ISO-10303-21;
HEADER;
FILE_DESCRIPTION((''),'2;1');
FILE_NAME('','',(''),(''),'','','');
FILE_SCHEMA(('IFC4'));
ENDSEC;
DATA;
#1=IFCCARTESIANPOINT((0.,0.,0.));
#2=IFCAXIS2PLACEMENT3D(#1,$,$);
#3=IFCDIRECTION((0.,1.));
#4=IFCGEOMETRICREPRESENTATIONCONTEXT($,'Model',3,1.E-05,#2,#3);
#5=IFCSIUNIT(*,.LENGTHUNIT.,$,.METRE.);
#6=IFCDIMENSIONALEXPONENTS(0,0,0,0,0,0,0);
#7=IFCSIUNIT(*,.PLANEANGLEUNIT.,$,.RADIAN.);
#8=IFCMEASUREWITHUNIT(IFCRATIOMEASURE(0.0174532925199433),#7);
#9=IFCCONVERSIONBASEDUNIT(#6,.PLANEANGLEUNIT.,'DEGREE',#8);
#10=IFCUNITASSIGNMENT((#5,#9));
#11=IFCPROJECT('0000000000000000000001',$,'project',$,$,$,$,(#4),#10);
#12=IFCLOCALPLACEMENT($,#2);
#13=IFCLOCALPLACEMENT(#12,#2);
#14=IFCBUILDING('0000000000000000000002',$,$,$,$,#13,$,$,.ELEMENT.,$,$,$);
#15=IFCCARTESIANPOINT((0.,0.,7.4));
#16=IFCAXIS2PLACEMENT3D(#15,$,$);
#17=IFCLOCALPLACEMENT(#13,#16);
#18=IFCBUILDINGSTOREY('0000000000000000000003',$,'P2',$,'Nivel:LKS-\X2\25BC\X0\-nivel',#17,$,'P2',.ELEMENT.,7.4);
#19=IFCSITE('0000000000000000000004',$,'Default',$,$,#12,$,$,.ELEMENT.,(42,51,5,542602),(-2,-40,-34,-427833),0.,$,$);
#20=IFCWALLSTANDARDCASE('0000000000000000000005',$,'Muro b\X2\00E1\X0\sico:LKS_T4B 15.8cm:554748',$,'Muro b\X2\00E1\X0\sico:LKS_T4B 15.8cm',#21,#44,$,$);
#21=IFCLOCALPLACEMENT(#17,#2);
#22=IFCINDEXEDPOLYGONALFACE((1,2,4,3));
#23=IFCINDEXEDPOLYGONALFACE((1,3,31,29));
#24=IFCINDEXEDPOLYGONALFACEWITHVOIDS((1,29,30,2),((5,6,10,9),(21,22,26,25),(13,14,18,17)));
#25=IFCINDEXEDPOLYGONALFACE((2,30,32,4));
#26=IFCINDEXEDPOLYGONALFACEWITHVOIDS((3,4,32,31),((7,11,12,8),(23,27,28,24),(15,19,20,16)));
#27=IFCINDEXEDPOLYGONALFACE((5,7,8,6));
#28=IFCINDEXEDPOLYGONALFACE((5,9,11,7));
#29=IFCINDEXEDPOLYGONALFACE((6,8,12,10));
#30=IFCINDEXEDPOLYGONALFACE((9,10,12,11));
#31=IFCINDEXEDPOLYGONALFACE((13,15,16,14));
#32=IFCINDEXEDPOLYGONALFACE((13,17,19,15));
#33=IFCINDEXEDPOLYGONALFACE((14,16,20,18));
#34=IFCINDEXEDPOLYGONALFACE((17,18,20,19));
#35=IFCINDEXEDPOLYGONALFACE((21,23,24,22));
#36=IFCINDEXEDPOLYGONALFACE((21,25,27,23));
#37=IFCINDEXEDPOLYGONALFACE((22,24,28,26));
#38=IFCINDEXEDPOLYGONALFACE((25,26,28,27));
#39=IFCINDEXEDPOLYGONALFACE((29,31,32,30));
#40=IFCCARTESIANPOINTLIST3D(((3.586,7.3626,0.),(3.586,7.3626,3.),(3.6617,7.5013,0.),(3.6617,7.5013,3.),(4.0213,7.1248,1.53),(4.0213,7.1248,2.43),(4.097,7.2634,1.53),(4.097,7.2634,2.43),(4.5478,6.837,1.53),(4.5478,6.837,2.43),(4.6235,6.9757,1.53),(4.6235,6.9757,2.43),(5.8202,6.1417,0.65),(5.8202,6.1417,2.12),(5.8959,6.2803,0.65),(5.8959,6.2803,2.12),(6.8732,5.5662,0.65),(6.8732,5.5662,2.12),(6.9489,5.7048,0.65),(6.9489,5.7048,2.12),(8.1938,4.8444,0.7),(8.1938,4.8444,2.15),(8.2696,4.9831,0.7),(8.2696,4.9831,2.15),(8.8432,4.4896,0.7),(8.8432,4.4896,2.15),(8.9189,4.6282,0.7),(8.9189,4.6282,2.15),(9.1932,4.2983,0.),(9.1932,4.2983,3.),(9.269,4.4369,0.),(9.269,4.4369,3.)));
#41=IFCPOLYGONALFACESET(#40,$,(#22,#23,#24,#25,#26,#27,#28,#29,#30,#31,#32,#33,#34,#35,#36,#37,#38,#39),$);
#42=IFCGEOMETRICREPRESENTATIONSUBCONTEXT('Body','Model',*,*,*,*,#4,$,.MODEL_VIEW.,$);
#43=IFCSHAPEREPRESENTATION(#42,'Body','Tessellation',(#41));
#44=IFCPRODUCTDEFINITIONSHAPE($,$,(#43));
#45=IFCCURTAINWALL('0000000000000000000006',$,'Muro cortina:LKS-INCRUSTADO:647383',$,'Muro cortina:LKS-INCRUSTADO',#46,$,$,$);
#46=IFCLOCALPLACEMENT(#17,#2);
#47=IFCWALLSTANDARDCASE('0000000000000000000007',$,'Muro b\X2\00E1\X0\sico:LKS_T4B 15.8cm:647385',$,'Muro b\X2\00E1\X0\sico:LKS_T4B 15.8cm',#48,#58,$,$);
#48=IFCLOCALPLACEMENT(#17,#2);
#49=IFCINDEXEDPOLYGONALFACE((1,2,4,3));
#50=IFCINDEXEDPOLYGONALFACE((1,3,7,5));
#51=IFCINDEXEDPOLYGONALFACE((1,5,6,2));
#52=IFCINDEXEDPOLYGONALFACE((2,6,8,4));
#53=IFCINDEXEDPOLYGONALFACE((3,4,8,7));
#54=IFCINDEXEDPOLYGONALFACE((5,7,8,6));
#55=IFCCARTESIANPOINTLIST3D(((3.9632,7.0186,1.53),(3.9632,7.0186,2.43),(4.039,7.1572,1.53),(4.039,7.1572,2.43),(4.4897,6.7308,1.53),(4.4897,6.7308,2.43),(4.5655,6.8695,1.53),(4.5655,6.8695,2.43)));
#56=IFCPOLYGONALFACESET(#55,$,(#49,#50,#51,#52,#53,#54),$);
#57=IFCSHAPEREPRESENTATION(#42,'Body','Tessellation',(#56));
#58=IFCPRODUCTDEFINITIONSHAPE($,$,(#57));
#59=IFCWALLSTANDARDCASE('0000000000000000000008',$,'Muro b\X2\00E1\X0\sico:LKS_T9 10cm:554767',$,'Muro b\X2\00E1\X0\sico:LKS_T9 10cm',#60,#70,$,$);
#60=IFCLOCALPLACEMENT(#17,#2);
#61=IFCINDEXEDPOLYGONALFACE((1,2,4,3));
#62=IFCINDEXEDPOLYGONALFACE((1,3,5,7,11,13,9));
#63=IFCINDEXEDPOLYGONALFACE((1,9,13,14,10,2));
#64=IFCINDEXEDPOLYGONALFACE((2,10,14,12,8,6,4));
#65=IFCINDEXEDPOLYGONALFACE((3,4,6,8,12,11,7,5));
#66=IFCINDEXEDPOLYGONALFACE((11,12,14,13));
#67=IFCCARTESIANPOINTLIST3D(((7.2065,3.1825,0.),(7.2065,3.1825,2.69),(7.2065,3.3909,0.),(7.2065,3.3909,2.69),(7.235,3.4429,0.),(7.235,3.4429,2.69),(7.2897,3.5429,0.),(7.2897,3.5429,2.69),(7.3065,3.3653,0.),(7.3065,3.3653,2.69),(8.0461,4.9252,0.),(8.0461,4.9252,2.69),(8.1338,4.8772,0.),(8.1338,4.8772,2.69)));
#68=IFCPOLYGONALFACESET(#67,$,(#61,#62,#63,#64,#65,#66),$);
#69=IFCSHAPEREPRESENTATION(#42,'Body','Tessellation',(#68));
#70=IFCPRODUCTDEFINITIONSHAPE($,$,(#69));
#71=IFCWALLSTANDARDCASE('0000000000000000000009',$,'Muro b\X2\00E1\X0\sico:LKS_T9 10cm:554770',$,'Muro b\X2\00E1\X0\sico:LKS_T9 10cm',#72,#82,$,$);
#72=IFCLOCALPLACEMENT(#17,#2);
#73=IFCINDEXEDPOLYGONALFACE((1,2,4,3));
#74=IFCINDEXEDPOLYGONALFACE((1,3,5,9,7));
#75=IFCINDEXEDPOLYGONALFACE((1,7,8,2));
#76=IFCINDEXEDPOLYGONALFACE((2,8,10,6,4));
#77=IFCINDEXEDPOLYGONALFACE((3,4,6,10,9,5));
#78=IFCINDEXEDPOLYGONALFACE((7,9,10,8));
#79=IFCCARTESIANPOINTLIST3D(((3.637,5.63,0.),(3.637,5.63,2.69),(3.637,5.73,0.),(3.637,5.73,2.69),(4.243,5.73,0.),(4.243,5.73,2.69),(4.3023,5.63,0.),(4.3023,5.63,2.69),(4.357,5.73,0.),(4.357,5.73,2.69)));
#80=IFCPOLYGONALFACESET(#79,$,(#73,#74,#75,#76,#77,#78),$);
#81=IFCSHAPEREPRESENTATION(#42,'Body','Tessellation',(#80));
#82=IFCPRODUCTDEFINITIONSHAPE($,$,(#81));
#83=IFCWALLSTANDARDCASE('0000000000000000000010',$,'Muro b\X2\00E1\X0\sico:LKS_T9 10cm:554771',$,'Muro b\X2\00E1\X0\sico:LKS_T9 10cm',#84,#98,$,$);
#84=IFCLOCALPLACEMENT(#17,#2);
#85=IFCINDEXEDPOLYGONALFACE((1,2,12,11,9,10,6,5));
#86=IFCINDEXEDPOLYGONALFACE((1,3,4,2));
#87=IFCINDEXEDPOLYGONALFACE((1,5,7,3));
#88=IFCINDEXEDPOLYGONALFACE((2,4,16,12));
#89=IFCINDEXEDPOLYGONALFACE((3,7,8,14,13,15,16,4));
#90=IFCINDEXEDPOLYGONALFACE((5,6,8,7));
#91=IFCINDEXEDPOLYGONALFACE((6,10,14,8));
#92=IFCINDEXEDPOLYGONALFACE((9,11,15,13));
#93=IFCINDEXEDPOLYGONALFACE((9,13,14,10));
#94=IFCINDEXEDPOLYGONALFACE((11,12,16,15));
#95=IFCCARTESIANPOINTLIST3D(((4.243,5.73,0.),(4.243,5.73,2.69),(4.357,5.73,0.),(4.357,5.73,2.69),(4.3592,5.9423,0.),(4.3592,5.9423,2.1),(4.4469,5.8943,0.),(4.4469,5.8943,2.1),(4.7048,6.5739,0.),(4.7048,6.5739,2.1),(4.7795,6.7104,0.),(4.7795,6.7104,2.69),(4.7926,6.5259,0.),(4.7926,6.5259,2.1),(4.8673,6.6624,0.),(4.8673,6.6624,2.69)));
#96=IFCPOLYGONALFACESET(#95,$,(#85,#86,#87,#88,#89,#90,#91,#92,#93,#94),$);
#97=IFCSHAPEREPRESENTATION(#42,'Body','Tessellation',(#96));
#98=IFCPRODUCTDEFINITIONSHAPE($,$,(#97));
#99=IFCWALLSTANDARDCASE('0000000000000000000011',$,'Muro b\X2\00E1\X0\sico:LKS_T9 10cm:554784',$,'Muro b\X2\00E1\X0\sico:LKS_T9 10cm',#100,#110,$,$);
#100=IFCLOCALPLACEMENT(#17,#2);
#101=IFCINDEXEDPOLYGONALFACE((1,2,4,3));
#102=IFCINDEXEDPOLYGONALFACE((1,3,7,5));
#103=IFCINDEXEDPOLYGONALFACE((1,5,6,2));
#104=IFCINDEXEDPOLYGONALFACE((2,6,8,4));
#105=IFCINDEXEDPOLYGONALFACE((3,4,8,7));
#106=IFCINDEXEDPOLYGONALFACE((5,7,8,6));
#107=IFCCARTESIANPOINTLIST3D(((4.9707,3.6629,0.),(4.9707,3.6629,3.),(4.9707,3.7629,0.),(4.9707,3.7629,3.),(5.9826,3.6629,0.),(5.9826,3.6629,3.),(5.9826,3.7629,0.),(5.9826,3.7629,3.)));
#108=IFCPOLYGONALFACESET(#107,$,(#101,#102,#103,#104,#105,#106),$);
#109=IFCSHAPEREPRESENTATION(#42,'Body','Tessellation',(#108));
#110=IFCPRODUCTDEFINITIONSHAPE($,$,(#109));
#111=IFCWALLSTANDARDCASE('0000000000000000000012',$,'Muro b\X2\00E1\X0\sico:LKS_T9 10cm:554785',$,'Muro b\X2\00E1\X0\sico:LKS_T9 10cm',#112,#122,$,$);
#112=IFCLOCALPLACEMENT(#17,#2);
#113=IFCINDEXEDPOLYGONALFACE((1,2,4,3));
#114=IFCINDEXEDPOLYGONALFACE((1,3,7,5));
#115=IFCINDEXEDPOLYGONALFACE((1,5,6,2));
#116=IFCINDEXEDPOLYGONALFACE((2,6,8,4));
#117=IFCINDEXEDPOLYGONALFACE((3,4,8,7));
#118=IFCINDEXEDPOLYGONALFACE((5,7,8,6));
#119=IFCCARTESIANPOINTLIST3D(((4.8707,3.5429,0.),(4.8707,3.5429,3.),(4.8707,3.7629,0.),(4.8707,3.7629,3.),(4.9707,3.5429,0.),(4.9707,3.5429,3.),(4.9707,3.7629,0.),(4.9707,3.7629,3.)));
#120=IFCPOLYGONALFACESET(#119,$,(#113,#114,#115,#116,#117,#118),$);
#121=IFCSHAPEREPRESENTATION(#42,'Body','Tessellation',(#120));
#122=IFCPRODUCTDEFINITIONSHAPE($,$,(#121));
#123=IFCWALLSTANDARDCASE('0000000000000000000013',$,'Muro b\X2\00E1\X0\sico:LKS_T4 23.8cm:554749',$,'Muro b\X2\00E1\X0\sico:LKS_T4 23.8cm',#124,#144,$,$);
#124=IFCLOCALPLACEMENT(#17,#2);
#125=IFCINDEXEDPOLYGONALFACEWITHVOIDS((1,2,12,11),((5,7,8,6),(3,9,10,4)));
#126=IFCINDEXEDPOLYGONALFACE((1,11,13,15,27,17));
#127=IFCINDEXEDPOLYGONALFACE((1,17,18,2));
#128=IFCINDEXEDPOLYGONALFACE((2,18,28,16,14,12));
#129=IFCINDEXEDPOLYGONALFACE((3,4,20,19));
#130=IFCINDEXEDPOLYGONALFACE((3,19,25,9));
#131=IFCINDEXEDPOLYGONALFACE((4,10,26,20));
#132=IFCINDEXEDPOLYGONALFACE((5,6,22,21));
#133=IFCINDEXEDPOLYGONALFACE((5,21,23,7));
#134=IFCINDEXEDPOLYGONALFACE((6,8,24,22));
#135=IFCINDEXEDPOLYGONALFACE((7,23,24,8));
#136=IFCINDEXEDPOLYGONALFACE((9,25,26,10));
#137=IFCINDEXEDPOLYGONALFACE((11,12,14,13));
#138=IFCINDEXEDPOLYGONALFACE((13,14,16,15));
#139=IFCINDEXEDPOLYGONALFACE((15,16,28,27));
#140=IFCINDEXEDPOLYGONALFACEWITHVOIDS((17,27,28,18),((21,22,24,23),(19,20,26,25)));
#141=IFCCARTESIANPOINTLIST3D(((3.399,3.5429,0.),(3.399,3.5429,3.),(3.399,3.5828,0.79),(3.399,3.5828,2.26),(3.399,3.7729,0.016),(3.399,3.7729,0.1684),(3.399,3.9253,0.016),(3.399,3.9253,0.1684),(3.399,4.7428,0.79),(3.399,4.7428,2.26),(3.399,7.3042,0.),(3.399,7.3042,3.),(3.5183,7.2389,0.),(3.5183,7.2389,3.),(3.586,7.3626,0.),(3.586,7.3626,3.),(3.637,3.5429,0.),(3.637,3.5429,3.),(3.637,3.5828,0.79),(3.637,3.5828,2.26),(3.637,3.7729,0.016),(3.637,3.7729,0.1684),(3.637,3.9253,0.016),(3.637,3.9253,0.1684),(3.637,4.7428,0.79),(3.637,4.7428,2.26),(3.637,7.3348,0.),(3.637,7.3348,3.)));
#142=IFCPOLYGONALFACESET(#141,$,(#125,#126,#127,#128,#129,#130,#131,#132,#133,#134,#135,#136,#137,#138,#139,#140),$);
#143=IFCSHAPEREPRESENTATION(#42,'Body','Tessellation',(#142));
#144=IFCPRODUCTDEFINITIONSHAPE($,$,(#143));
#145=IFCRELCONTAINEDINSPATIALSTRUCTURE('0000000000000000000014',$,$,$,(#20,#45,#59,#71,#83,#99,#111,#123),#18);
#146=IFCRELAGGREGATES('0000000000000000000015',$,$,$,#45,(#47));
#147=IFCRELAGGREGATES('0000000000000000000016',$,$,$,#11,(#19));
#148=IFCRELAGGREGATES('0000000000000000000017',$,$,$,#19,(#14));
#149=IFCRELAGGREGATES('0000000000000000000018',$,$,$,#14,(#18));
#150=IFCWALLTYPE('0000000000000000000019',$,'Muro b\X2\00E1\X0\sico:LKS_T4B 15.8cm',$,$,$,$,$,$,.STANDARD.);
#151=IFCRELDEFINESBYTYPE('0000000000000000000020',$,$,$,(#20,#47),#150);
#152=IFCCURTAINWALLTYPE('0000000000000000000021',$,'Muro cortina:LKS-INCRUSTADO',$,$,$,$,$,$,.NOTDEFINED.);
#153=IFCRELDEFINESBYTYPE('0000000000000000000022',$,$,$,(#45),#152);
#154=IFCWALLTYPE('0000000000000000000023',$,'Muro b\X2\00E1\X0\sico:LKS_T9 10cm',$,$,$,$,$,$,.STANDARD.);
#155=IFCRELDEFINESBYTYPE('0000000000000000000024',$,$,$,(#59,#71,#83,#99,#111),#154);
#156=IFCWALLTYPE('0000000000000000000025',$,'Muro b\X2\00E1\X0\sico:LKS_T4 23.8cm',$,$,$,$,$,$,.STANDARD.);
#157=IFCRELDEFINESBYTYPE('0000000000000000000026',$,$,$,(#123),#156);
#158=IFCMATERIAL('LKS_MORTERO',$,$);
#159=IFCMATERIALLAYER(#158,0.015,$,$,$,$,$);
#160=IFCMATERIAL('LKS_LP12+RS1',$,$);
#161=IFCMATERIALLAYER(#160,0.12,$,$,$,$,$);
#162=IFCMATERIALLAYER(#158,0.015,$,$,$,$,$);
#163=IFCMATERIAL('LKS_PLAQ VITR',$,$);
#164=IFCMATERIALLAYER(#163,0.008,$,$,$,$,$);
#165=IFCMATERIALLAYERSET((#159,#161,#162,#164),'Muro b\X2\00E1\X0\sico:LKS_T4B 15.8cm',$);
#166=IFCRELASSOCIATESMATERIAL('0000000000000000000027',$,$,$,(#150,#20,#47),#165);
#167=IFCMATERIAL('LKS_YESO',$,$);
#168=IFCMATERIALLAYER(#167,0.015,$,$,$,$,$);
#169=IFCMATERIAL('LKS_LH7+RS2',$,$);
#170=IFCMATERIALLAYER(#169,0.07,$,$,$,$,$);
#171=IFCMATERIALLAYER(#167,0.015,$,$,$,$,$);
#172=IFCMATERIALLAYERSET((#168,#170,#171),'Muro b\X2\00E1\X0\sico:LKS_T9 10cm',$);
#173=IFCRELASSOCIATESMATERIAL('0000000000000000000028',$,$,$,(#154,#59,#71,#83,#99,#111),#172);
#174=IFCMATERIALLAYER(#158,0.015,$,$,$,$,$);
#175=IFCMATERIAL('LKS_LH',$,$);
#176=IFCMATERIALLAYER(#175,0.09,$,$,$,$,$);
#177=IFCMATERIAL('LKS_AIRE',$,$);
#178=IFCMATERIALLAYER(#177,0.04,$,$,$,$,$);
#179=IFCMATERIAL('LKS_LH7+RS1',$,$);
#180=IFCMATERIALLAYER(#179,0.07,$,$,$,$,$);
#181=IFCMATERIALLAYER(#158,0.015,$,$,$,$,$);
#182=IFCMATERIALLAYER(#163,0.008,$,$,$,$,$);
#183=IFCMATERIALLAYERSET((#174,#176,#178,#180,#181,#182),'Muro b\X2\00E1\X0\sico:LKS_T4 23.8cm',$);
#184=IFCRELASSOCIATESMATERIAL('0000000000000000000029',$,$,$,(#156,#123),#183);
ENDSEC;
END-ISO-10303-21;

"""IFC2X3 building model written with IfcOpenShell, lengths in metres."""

from ifc_helpers import new_model, entity, si_unit, converted_unit, direction, frame, frame_2d, origin, place, context, subcontext, project, spatial, polyline, rectangle, outline, extrude, clip, bounded_halfspace, material, layer, layer_set, layer_usage, type_object, element, aggregate, save


model = new_model("IFC2X3")

# Units and contexts
model_context = context("Model", 3, precision=1e-05, world=origin(), true_north=direction((0.0, 1.0)))
body_context = subcontext(model_context, "Body", "Model", "MODEL_VIEW")
ifc_project = project(units=[si_unit("LENGTHUNIT", "METRE"), converted_unit("PLANEANGLEUNIT", "DEGREE", entity("IfcRatioMeasure", 0.0174532925199433), si_unit("PLANEANGLEUNIT", "RADIAN"), dimensions=[0, 0, 0, 0, 0, 0, 0])], contexts=[model_context])

# Site, building, storey
site_placement = place(None, origin())
site = spatial("IfcSite", under=ifc_project, at=site_placement, Name="Default", CompositionType="ELEMENT", RefLatitude=(42, 51, 5, 542602), RefLongitude=(-2, -40, -34, -427833), RefElevation=0.0)
building_placement = place(site_placement, origin())
building = spatial("IfcBuilding", under=site, at=building_placement, CompositionType="ELEMENT")
storey_placement = place(building_placement, frame((0.0, 0.0, 7.4)))
storey = spatial("IfcBuildingStorey", under=building, at=storey_placement, Name="P2", ObjectType="Nivel:LKS-▼-nivel", LongName="P2", CompositionType="ELEMENT", Elevation=7.4)

# Wall, openings
ifc_material_1 = material(Name="LKS_MORTERO")
ifc_layer_1 = layer(ifc_material_1, 0.015)
ifc_material_2 = material(Name="LKS_LP12+RS1")
ifc_layer_2 = layer(ifc_material_2, 0.12)
ifc_layer_3 = layer(ifc_material_1, 0.015)
ifc_material_3 = material(Name="LKS_PLAQ VITR")
ifc_layer_4 = layer(ifc_material_3, 0.008)
ifc_layer_set_1 = layer_set([ifc_layer_1, ifc_layer_2, ifc_layer_3, ifc_layer_4], Name="Muro básico:LKS_T4B 15.8cm")
ifc_layer_usage_1 = layer_usage(ifc_layer_set_1, "AXIS2", "POSITIVE", -0.079)
wall_type_1 = type_object("IfcWallType", Name="Muro básico:LKS_T4B 15.8cm", PredefinedType="STANDARD", material=ifc_layer_set_1)
wall_1_placement = place(storey_placement, frame((9.2311, 4.3676, 0.0), z_axis=(0.0, 0.0, 1.0), x_axis=(-0.877509, 0.479561, 0.0)))
wall_1 = element("IfcWallStandardCase", 1, at=wall_1_placement, inside=storey, type_object=wall_type_1, material=ifc_layer_usage_1, Name="Muro básico:LKS_T4B 15.8cm:554748", ObjectType="Muro básico:LKS_T4B 15.8cm", context=body_context, shape_type="Clipping", body=[
    clip(clip(extrude(rectangle(XDim=6.39, YDim=0.158, at=frame_2d((3.195, 0.0), x_axis=(-1.0, 0.0))), origin(), (0.0, 0.0, 1.0), 3.0), bounded_halfspace(frame((0.0, -0.079, 0.0), z_axis=(1.0, 0.0, 0.0), x_axis=(0.0, 0.0, -1.0)), True, frame((0.0, -0.079, 0.0), z_axis=(1.0, 0.0, 0.0), x_axis=(0.0, 0.0, -1.0)), polyline([(0.0, 0.0), (0.0, 0.158), (-3.0, 0.158), (-3.0, 0.0488), (-3.0, 0.0), (0.0, 0.0)]))), bounded_halfspace(frame((6.39, -0.079, 3.0), z_axis=(-1.0, 0.0, 0.0), x_axis=(0.0, 0.0, -1.0)), True, frame((6.39, -0.079, 3.0), z_axis=(-1.0, 0.0, 0.0), x_axis=(0.0, 0.0, -1.0)), polyline([(0.0, 0.0), (0.0, -0.0455), (0.0, -0.158), (3.0, -0.158), (3.0, 0.0), (0.0, 0.0)]))),
])
opening_1_placement = place(wall_1_placement, origin())
element("IfcOpeningElement", 2, at=opening_1_placement, cuts=wall_1, ObjectType="Opening", context=body_context, shape_type="SweptSolid", body=[
    extrude(rectangle(XDim=0.9, YDim=0.6, at=frame_2d((0.0, 0.0), x_axis=(0.0, 1.0))), frame((5.5939, -0.2314, 1.98), z_axis=(0.0, 1.0, 0.0), x_axis=(-1.0, 0.0, 0.0)), (0.0, 0.0, 1.0), 0.4628),
])
opening_2_placement = place(wall_1_placement, frame((3.8439, 0.079, 0.65)))
element("IfcOpeningElement", 3, at=opening_2_placement, cuts=wall_1, ObjectType="Opening", context=body_context, shape_type="SweptSolid", body=[
    extrude(rectangle(XDim=1.47, YDim=1.2, at=frame_2d((0.735, 0.6), x_axis=(1.0, 0.0))), frame((0.0, 0.0, 0.0), z_axis=(0.0, -1.0, 0.0), x_axis=(0.0, 0.0, 1.0)), (0.0, 0.0, 1.0), 0.158),
])
opening_3_placement = place(wall_1_placement, frame((1.1389, 0.079, 0.7)))
element("IfcOpeningElement", 4, at=opening_3_placement, cuts=wall_1, ObjectType="Opening", context=body_context, shape_type="SweptSolid", body=[
    extrude(rectangle(XDim=1.45, YDim=0.74, at=frame_2d((0.725, 0.37), x_axis=(1.0, 0.0))), frame((0.0, 0.0, 0.0), z_axis=(0.0, -1.0, 0.0), x_axis=(0.0, 0.0, 1.0)), (0.0, 0.0, 1.0), 0.158),
])

# Curtain wall, wall
curtain_wall_type = type_object("IfcCurtainWallType", Name="Muro cortina:LKS-INCRUSTADO", PredefinedType="NOTDEFINED")
curtain_wall_placement = place(storey_placement, frame((0.0, 0.0, -7.4)))
curtain_wall = element("IfcCurtainWall", 5, at=curtain_wall_placement, inside=storey, type_object=curtain_wall_type, Name="Muro cortina:LKS-INCRUSTADO:647383", ObjectType="Muro cortina:LKS-INCRUSTADO")
ifc_layer_usage_2 = layer_usage(ifc_layer_set_1, "AXIS2", "NEGATIVE", 0.079)
wall_2_placement = place(storey_placement, frame((4.0011, 7.0879, 1.53), z_axis=(0.0, 0.0, 1.0), x_axis=(0.877509, -0.479561, 0.0)))
wall_2 = element("IfcWallStandardCase", 6, at=wall_2_placement, type_object=wall_type_1, material=ifc_layer_usage_2, Name="Muro básico:LKS_T4B 15.8cm:647385", ObjectType="Muro básico:LKS_T4B 15.8cm", context=body_context, shape_type="SweptSolid", body=[
    extrude(rectangle(XDim=0.6, YDim=0.158, at=frame_2d((0.3, 0.0), x_axis=(-1.0, 0.0))), origin(), (0.0, 0.0, 1.0), 0.9),
])
aggregate(curtain_wall, [wall_2])

# Walls
ifc_material_4 = material(Name="LKS_YESO")
ifc_layer_5 = layer(ifc_material_4, 0.015)
ifc_material_5 = material(Name="LKS_LH7+RS2")
ifc_layer_6 = layer(ifc_material_5, 0.07)
ifc_layer_7 = layer(ifc_material_4, 0.015)
ifc_layer_set_2 = layer_set([ifc_layer_5, ifc_layer_6, ifc_layer_7], Name="Muro básico:LKS_T9 10cm")
ifc_layer_usage_3 = layer_usage(ifc_layer_set_2, "AXIS2", "NEGATIVE", 0.05)
wall_type_2 = type_object("IfcWallType", Name="Muro básico:LKS_T9 10cm", PredefinedType="STANDARD", material=ifc_layer_set_2)
wall_3_placement = place(storey_placement, frame((8.09, 4.9012, 0.0), z_axis=(0.0, 0.0, 1.0), x_axis=(-0.480022, -0.877256, 0.0)))
element("IfcWallStandardCase", 7, at=wall_3_placement, inside=storey, type_object=wall_type_2, material=ifc_layer_usage_3, Name="Muro básico:LKS_T9 10cm:554767", ObjectType="Muro básico:LKS_T9 10cm", context=body_context, shape_type="SweptSolid", body=[
    extrude(outline(polyline([(1.749, -0.05), (1.9318, 0.05), (1.7235, 0.05), (0.0, 0.05), (0.0001, -0.05), (1.5758, -0.05), (1.6897, -0.05), (1.749, -0.05)])), origin(), (0.0, 0.0, 1.0), 2.69),
])
ifc_layer_usage_4 = layer_usage(ifc_layer_set_2, "AXIS2", "NEGATIVE", 0.05)
wall_4_placement = place(storey_placement, frame((3.637, 5.68, 0.0)))
element("IfcWallStandardCase", 8, at=wall_4_placement, inside=storey, type_object=wall_type_2, material=ifc_layer_usage_4, Name="Muro básico:LKS_T9 10cm:554770", ObjectType="Muro básico:LKS_T9 10cm", context=body_context, shape_type="SweptSolid", body=[
    extrude(outline(polyline([(0.6654, -0.05), (0.7201, 0.05), (0.6061, 0.05), (0.0, 0.05), (0.0, -0.05), (0.6654, -0.05)])), origin(), (0.0, 0.0, 1.0), 2.69),
])

# Wall, opening
ifc_layer_usage_5 = layer_usage(ifc_layer_set_2, "AXIS2", "NEGATIVE", 0.05)
wall_5_placement = place(storey_placement, frame((4.2869, 5.706, 0.0), z_axis=(0.0, 0.0, 1.0), x_axis=(0.480022, 0.877256, 0.0)))
wall_5 = element("IfcWallStandardCase", 9, at=wall_5_placement, inside=storey, type_object=wall_type_2, material=ifc_layer_usage_5, Name="Muro básico:LKS_T9 10cm:554771", ObjectType="Muro básico:LKS_T9 10cm", context=body_context, shape_type="SweptSolid", body=[
    extrude(outline(polyline([(0.0547, -0.05), (1.1176, -0.05), (1.1176, 0.05), (0.0, 0.05), (0.0547, -0.05)])), origin(), (0.0, 0.0, 1.0), 2.69),
])
opening_4_placement = place(wall_5_placement, frame((0.962, 0.05, 0.0)))
element("IfcOpeningElement", 10, at=opening_4_placement, cuts=wall_5, ObjectType="Opening", context=body_context, shape_type="SweptSolid", body=[
    extrude(rectangle(XDim=2.1, YDim=0.72, at=frame_2d((1.05, 0.36), x_axis=(1.0, 0.0))), frame((0.0, 0.0, 0.0), z_axis=(0.0, -1.0, 0.0), x_axis=(0.0, 0.0, 1.0)), (0.0, 0.0, 1.0), 0.1),
])

# Walls
ifc_layer_usage_6 = layer_usage(ifc_layer_set_2, "AXIS2", "NEGATIVE", 0.05)
wall_6_placement = place(storey_placement, frame((5.9826, 3.7129, 0.0), z_axis=(0.0, 0.0, 1.0), x_axis=(-1.0, 0.0, 0.0)))
element("IfcWallStandardCase", 11, at=wall_6_placement, inside=storey, type_object=wall_type_2, material=ifc_layer_usage_6, Name="Muro básico:LKS_T9 10cm:554784", ObjectType="Muro básico:LKS_T9 10cm", context=body_context, shape_type="SweptSolid", body=[
    extrude(rectangle(XDim=1.012, YDim=0.1, at=frame_2d((0.506, 0.0), x_axis=(-1.0, 0.0))), origin(), (0.0, 0.0, 1.0), 3.0),
])
ifc_layer_usage_7 = layer_usage(ifc_layer_set_2, "AXIS2", "NEGATIVE", 0.05)
wall_7_placement = place(storey_placement, frame((4.9207, 3.7629, 0.0), z_axis=(0.0, 0.0, 1.0), x_axis=(0.0, -1.0, 0.0)))
element("IfcWallStandardCase", 12, at=wall_7_placement, inside=storey, type_object=wall_type_2, material=ifc_layer_usage_7, Name="Muro básico:LKS_T9 10cm:554785", ObjectType="Muro básico:LKS_T9 10cm", context=body_context, shape_type="SweptSolid", body=[
    extrude(rectangle(XDim=0.22, YDim=0.1, at=frame_2d((0.11, 0.0), x_axis=(-1.0, 0.0))), origin(), (0.0, 0.0, 1.0), 3.0),
])

# Wall, openings
ifc_layer_8 = layer(ifc_material_1, 0.015)
ifc_material_6 = material(Name="LKS_LH")
ifc_layer_9 = layer(ifc_material_6, 0.09)
ifc_material_7 = material(Name="LKS_AIRE")
ifc_layer_10 = layer(ifc_material_7, 0.04)
ifc_material_8 = material(Name="LKS_LH7+RS1")
ifc_layer_11 = layer(ifc_material_8, 0.07)
ifc_layer_12 = layer(ifc_material_1, 0.015)
ifc_layer_13 = layer(ifc_material_3, 0.008)
ifc_layer_set_3 = layer_set([ifc_layer_8, ifc_layer_9, ifc_layer_10, ifc_layer_11, ifc_layer_12, ifc_layer_13], Name="Muro básico:LKS_T4 23.8cm")
ifc_layer_usage_8 = layer_usage(ifc_layer_set_3, "AXIS2", "NEGATIVE", 0.119)
wall_type_3 = type_object("IfcWallType", Name="Muro básico:LKS_T4 23.8cm", PredefinedType="STANDARD", material=ifc_layer_set_3)
wall_8_placement = place(storey_placement, frame((3.518, 7.3348, 0.0), z_axis=(0.0, 0.0, 1.0), x_axis=(0.0, -1.0, 0.0)))
wall_8 = element("IfcWallStandardCase", 13, at=wall_8_placement, inside=storey, type_object=wall_type_3, material=ifc_layer_usage_8, Name="Muro básico:LKS_T4 23.8cm:554749", ObjectType="Muro básico:LKS_T4 23.8cm", context=body_context, shape_type="Clipping", body=[
    clip(clip(extrude(outline(polyline([(0.0, 0.119), (-0.0276, 0.0685), (-0.0279, 0.068), (0.0959, 0.0004), (0.0306, -0.119), (0.0318, -0.119), (3.7651, -0.119), (3.7919, -0.119), (3.7919, 0.111), (3.7919, 0.119), (1.7048, 0.119), (1.6048, 0.119), (0.0, 0.119)])), origin(), (0.0, 0.0, 1.0), 3.0), bounded_halfspace(frame((0.0959, 0.0004, 0.0), z_axis=(0.479561, 0.877509, 0.0), x_axis=(0.0, 0.0, -1.0)), True, frame((0.0959, 0.0004, 0.0), z_axis=(0.479561, 0.877509, 0.0), x_axis=(0.0, 0.0, -1.0)), polyline([(0.0, 0.0), (0.0, 0.141), (-3.0, 0.141), (-3.0, 0.0), (-2.67, 0.0), (0.0, 0.0)]))), bounded_halfspace(frame((0.0959, 0.0004, 3.0), z_axis=(0.877509, -0.479561, 0.0), x_axis=(0.0, 0.0, -1.0)), True, frame((0.0959, 0.0004, 3.0), z_axis=(0.877509, -0.479561, 0.0), x_axis=(0.0, 0.0, -1.0)), polyline([(0.0, 0.0), (0.0, -0.0791), (0.0, -0.1361), (3.0, -0.1361), (3.0, 0.0), (0.33, 0.0), (0.0, 0.0)]))),
])
opening_5_placement = place(wall_8_placement, origin())
element("IfcOpeningElement", 14, at=opening_5_placement, cuts=wall_8, ObjectType="Opening", context=body_context, shape_type="SweptSolid", body=[
    extrude(rectangle(XDim=0.1524, YDim=0.1524, at=frame_2d((0.0, 0.0), x_axis=(0.0, 1.0))), frame((3.4857, -1.405, 0.0922), z_axis=(0.0, 1.0, 0.0), x_axis=(-1.0, 0.0, 0.0)), (0.0, 0.0, 1.0), 3.048),
])
opening_6_placement = place(wall_8_placement, frame((3.752, 0.119, 0.79)))
element("IfcOpeningElement", 15, at=opening_6_placement, cuts=wall_8, ObjectType="Opening", context=body_context, shape_type="SweptSolid", body=[
    extrude(rectangle(XDim=1.47, YDim=1.16, at=frame_2d((0.735, 0.58), x_axis=(1.0, 0.0))), frame((0.0, 0.0, 0.0), z_axis=(0.0, -1.0, 0.0), x_axis=(0.0, 0.0, 1.0)), (0.0, 0.0, 1.0), 0.238),
])

save(model, "model.ifc")
